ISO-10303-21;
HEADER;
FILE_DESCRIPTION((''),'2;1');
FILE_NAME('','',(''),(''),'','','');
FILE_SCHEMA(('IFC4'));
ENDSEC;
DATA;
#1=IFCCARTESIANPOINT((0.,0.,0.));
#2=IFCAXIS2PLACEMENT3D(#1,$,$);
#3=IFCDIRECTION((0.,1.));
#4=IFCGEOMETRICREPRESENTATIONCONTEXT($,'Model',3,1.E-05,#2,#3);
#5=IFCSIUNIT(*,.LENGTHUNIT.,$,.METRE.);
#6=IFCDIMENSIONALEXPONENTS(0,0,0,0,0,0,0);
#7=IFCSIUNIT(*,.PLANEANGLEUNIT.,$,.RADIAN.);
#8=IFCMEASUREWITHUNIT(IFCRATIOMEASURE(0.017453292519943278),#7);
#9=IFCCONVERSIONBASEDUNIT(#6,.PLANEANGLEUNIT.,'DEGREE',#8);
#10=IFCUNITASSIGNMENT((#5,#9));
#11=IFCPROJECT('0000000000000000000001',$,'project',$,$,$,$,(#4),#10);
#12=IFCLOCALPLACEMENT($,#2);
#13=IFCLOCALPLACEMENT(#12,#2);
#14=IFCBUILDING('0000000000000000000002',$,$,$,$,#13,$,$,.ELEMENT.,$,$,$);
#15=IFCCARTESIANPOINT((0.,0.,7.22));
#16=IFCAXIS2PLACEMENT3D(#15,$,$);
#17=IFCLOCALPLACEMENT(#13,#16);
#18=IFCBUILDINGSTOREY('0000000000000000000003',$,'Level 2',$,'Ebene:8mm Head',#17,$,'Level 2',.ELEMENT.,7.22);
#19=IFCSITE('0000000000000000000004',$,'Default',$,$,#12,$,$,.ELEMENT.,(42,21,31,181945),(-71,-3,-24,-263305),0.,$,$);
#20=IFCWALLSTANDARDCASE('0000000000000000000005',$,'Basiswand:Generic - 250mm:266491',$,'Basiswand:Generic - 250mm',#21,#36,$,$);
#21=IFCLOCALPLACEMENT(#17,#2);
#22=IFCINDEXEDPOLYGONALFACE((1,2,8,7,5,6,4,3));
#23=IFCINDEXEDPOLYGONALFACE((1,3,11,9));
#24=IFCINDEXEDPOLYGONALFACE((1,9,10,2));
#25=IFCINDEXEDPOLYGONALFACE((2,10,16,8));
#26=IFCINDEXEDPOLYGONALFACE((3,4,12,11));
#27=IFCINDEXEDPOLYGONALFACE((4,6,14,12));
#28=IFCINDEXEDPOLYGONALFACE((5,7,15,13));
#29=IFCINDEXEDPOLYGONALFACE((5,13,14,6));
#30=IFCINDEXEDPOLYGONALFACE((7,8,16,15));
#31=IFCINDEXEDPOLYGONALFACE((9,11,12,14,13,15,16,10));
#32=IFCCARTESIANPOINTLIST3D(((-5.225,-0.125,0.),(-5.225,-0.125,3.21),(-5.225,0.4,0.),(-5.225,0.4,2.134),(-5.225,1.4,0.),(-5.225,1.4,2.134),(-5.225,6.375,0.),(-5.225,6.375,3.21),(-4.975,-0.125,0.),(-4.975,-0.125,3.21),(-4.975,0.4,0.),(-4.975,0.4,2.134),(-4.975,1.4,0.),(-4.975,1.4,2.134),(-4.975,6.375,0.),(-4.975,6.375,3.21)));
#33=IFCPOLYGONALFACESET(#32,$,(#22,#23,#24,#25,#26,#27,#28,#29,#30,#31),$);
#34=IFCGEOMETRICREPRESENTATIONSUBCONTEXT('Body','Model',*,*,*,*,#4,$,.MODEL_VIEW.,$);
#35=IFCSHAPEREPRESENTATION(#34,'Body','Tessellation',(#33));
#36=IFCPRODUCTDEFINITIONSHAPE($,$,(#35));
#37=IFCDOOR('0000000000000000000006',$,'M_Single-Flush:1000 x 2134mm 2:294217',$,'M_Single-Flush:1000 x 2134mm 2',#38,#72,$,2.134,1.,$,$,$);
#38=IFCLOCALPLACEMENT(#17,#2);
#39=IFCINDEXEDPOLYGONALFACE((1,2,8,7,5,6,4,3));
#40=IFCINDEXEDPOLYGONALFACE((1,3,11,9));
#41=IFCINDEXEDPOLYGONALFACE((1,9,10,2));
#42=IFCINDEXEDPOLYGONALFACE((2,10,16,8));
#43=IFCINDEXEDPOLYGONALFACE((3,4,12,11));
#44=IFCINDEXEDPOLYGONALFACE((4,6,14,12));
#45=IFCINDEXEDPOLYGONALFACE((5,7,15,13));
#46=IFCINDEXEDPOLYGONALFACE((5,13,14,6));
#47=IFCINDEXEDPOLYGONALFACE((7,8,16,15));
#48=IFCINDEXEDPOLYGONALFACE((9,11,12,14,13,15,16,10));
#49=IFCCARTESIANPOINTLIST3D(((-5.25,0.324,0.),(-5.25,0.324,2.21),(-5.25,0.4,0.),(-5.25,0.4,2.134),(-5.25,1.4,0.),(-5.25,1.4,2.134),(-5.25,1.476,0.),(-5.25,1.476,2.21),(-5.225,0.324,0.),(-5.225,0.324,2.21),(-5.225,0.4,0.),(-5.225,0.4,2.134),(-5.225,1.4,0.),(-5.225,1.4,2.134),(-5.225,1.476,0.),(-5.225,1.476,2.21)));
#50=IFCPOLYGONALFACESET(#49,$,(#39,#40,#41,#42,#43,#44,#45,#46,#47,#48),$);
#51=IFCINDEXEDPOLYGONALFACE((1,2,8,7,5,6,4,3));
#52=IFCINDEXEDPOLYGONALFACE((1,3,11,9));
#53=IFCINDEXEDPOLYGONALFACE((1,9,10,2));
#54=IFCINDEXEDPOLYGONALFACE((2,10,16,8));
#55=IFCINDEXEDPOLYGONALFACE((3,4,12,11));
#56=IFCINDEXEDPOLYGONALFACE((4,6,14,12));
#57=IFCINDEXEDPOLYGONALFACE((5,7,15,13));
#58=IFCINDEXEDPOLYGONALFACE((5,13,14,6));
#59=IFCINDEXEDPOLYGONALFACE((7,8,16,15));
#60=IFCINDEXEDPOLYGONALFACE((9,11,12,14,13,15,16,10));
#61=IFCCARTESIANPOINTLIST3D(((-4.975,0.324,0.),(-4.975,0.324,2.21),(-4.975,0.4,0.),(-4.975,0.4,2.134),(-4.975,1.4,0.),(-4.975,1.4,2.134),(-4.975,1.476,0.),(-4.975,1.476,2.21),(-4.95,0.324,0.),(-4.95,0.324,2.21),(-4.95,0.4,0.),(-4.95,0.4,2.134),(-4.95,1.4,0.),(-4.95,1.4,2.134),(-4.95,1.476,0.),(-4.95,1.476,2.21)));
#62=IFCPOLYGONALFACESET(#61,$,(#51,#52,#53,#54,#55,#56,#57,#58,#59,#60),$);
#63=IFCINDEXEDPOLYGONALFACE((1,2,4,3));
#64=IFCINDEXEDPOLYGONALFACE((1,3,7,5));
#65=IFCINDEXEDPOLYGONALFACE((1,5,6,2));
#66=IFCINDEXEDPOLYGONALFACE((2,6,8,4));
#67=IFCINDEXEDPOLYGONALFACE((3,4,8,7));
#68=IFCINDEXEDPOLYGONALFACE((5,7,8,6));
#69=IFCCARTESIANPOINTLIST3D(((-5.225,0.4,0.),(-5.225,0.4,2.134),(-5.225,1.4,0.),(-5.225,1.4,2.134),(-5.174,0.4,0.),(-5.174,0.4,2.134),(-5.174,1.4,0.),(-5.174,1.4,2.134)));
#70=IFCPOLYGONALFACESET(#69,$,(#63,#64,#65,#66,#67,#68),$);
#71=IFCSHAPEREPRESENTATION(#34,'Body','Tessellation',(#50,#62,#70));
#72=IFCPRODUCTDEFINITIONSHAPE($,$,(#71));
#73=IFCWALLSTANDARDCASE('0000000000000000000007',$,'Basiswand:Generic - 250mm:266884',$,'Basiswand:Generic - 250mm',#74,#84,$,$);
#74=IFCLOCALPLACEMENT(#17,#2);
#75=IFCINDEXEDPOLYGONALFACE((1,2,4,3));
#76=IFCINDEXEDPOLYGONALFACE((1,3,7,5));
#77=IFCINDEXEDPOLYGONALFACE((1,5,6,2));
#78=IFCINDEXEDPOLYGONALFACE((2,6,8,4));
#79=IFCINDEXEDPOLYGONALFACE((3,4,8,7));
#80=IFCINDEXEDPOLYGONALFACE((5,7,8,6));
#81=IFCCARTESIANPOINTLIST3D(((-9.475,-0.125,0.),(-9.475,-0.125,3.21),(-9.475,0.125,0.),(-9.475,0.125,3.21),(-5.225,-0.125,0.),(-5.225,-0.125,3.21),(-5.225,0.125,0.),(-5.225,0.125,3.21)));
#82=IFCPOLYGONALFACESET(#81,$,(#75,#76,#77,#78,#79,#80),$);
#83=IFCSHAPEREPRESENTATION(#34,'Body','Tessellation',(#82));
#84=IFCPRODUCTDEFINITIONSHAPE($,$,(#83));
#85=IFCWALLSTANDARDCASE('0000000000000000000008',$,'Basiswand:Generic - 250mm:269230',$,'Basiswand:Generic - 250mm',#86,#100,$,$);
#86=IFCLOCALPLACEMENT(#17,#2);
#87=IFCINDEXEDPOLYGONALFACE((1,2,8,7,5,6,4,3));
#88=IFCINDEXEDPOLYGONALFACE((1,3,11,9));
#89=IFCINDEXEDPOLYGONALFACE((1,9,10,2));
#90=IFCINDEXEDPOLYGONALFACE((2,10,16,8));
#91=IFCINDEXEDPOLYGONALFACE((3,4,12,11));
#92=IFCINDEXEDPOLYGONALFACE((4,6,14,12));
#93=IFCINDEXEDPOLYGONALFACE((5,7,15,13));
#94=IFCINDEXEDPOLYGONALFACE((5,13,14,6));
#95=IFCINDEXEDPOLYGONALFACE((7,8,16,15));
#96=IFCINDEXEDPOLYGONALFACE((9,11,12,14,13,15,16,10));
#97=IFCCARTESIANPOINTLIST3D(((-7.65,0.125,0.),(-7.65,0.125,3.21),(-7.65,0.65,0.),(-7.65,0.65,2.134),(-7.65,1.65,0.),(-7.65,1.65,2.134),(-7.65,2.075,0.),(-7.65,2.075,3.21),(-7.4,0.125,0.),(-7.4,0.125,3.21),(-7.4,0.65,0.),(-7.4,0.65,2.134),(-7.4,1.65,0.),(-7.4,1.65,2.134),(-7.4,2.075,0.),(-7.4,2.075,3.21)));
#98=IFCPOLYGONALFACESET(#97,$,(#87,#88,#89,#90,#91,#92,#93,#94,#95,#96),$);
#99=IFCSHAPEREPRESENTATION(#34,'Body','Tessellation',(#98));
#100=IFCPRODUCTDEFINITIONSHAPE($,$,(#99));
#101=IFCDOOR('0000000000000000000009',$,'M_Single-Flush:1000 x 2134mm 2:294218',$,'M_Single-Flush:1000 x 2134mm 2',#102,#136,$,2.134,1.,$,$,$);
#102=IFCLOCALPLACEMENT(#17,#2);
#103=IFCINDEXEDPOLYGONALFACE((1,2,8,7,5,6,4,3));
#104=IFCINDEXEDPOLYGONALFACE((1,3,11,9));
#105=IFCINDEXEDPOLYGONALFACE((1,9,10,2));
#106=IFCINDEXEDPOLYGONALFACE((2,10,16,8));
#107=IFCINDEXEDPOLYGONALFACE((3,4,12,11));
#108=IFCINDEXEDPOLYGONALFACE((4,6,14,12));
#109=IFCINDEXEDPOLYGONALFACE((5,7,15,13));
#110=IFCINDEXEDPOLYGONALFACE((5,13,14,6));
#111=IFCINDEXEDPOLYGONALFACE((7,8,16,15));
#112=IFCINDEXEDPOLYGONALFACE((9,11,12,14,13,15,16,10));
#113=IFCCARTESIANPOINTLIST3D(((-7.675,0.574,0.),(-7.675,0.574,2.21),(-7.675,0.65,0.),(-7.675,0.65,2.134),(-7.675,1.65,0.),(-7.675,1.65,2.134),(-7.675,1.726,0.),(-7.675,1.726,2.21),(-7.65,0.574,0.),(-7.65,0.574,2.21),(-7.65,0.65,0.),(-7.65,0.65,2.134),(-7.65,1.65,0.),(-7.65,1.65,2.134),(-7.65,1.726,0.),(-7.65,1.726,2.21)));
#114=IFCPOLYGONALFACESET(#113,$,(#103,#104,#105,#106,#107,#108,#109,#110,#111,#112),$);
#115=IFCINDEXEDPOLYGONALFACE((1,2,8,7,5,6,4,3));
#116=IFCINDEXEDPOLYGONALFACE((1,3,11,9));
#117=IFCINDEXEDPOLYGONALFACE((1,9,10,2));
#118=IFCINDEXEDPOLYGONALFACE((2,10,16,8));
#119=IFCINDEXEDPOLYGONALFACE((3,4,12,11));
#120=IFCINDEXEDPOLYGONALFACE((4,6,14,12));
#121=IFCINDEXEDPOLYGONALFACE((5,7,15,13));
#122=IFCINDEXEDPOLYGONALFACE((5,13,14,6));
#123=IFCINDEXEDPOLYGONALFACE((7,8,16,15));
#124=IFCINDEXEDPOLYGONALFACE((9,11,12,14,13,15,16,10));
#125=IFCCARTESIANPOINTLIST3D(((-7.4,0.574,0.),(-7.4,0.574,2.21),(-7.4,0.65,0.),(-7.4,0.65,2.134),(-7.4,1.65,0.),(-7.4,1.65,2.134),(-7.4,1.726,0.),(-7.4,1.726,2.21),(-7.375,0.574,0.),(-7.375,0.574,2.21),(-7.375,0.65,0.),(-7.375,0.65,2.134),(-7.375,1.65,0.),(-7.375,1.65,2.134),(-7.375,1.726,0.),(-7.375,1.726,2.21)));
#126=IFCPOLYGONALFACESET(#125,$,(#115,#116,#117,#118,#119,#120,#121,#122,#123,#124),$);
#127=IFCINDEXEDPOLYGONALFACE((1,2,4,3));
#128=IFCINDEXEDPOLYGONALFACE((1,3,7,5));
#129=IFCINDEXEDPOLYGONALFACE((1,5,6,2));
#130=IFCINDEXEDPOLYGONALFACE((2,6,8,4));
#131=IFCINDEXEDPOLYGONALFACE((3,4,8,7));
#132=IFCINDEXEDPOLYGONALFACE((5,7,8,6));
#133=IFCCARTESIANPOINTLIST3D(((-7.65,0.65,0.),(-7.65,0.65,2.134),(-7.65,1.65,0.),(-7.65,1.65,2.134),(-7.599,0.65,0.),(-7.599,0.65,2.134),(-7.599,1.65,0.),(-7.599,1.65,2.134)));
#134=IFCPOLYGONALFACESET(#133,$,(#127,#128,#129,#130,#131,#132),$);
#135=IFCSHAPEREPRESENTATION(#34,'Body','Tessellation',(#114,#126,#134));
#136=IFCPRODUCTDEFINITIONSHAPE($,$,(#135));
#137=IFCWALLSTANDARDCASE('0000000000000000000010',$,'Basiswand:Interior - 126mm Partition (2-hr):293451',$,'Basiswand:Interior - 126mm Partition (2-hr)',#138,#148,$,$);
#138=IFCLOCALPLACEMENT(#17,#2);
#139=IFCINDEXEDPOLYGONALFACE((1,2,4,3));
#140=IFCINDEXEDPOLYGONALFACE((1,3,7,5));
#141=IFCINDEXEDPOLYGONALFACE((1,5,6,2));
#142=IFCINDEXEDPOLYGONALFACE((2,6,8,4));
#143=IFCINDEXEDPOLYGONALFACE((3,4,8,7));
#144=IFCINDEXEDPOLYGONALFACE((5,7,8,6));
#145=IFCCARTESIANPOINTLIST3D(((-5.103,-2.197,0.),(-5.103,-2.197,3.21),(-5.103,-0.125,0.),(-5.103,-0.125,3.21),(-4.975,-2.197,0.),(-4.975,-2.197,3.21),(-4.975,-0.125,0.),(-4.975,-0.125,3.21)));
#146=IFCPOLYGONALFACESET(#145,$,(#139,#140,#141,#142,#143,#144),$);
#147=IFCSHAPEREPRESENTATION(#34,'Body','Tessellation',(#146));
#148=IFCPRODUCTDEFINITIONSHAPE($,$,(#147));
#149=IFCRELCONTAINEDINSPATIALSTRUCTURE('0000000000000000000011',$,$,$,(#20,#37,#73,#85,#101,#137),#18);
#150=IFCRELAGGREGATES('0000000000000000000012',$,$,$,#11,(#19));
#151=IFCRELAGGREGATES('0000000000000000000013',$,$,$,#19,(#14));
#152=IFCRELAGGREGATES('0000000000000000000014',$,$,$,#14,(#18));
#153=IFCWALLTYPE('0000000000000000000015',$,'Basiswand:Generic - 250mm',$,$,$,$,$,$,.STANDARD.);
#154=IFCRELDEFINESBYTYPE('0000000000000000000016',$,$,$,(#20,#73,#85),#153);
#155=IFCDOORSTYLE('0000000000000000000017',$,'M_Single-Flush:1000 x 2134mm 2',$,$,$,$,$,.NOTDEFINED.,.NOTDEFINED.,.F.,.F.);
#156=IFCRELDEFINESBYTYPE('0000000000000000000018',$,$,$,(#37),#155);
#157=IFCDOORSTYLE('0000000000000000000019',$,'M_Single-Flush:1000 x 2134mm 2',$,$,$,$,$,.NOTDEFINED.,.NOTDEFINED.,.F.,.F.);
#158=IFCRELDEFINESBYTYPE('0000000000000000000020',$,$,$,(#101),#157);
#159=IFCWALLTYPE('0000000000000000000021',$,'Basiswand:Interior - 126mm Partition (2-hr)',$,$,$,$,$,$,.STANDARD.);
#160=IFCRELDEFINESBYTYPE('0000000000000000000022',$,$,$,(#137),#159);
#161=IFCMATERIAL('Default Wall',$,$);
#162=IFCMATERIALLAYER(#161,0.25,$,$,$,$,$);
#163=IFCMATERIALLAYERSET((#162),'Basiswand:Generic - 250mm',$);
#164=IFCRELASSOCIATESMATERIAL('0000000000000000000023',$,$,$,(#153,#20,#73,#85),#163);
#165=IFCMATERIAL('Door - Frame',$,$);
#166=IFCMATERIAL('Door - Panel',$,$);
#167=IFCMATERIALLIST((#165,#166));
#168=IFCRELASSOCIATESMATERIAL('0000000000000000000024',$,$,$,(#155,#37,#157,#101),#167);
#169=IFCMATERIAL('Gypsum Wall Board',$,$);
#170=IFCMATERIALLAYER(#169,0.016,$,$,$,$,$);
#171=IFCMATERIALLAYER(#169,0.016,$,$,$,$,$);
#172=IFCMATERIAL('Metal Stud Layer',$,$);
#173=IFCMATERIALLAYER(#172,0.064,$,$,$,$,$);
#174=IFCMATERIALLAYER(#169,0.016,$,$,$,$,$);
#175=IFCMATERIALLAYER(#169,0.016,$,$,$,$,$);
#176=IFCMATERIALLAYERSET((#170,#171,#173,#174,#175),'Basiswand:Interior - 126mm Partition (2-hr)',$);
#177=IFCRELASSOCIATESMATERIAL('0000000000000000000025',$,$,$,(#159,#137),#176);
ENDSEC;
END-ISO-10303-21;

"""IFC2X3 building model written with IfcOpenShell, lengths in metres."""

from ifc_helpers import new_model, entity, si_unit, converted_unit, direction, frame, frame_2d, origin, place, context, subcontext, project, spatial, polyline, rectangle, outline, extrude, clip, bounded_halfspace, source, transform, mapped, material, material_list, layer, layer_set, layer_usage, type_object, type_shapes, element, fill, save


model = new_model("IFC2X3")

# Units and contexts
model_context = context("Model", 3, precision=1e-05, world=origin(), true_north=direction((0.0, 1.0)))
body_context = subcontext(model_context, "Body", "Model", "MODEL_VIEW")
ifc_project = project(units=[si_unit("LENGTHUNIT", "METRE"), converted_unit("PLANEANGLEUNIT", "DEGREE", entity("IfcRatioMeasure", 0.017453292519943278), si_unit("PLANEANGLEUNIT", "RADIAN"), dimensions=[0, 0, 0, 0, 0, 0, 0])], contexts=[model_context])

# Site, building, storey
site_placement = place(None, origin())
site = spatial("IfcSite", under=ifc_project, at=site_placement, Name="Default", CompositionType="ELEMENT", RefLatitude=(42, 21, 31, 181945), RefLongitude=(-71, -3, -24, -263305), RefElevation=0.0)
building_placement = place(site_placement, origin())
building = spatial("IfcBuilding", under=site, at=building_placement, CompositionType="ELEMENT")
storey_placement = place(building_placement, frame((0.0, 0.0, 7.22)))
storey = spatial("IfcBuildingStorey", under=building, at=storey_placement, Name="Level 2", ObjectType="Ebene:8mm Head", LongName="Level 2", CompositionType="ELEMENT", Elevation=7.22)

# Wall, opening, door
ifc_material_1 = material(Name="Default Wall")
ifc_layer_1 = layer(ifc_material_1, 0.25)
ifc_layer_set_1 = layer_set([ifc_layer_1], Name="Basiswand:Generic - 250mm")
ifc_layer_usage_1 = layer_usage(ifc_layer_set_1, "AXIS2", "NEGATIVE", 0.125)
wall_type_1 = type_object("IfcWallType", Name="Basiswand:Generic - 250mm", PredefinedType="STANDARD", material=ifc_layer_set_1)
wall_1_placement = place(storey_placement, frame((-5.1, -0.125, 0.0), z_axis=(0.0, 0.0, 1.0), x_axis=(0.0, 1.0, 0.0)))
wall_1 = element("IfcWallStandardCase", 1, at=wall_1_placement, inside=storey, type_object=wall_type_1, material=ifc_layer_usage_1, Name="Basiswand:Generic - 250mm:266491", ObjectType="Basiswand:Generic - 250mm", context=body_context, shape_type="SweptSolid", body=[
    extrude(rectangle(XDim=6.5, YDim=0.25, at=frame_2d((3.25, 0.0), x_axis=(1.0, 0.0))), origin(), (0.0, 0.0, 1.0), 3.21),
])
opening_1_placement = place(wall_1_placement, frame((0.525, -0.125, 0.0)))
opening_1 = element("IfcOpeningElement", 2, at=opening_1_placement, cuts=wall_1, ObjectType="Opening", context=body_context, shape_type="SweptSolid", body=[
    extrude(rectangle(XDim=1.0, YDim=2.134, at=frame_2d((1.067, 0.5), x_axis=(0.0, -1.0))), frame((0.0, 0.0, 0.0), z_axis=(0.0, 1.0, 0.0), x_axis=(0.0, 0.0, 1.0)), (0.0, 0.0, 1.0), 0.25),
])
ifc_material_2 = material(Name="Door - Frame")
ifc_material_3 = material(Name="Door - Panel")
ifc_material_list_1 = material_list([ifc_material_2, ifc_material_3])
door_style_1 = type_object("IfcDoorStyle", Name="M_Single-Flush:1000 x 2134mm 2", ConstructionType="NOTDEFINED", OperationType="NOTDEFINED", ParameterTakesPrecedence=False, Sizeable=False, material=ifc_material_list_1)
shared_shape_1 = source(origin(), body_context, "Body", "SweptSolid", [
    extrude(outline(polyline([(-0.576, -1.124), (0.576, -1.124), (0.576, 1.086), (0.5, 1.086), (0.5, -1.048), (-0.5, -1.048), (-0.5, 1.086), (-0.576, 1.086), (-0.576, -1.124)])), frame((0.5, 0.275, 1.086), z_axis=(0.0, -1.0, 0.0), x_axis=(-1.0, 0.0, 0.0)), (0.0, 0.0, 1.0), 0.025),
    extrude(outline(polyline([(-1.124, -0.576), (1.086, -0.576), (1.086, -0.5), (-1.048, -0.5), (-1.048, 0.5), (1.086, 0.5), (1.086, 0.576), (-1.124, 0.576), (-1.124, -0.576)])), frame((0.5, 0.0, 1.086), z_axis=(0.0, -1.0, 0.0), x_axis=(0.0, 0.0, -1.0)), (0.0, 0.0, 1.0), 0.025),
    extrude(rectangle(XDim=1.0, YDim=0.051, at=frame_2d((0.0, 0.0), x_axis=(1.0, 0.0))), frame((0.5, 0.2245, 0.0)), (0.0, 0.0, 1.0), 2.134),
])
type_shapes(door_style_1, [shared_shape_1])
door_1_placement = place(opening_1_placement, origin())
door_1 = element("IfcDoor", 3, at=door_1_placement, inside=storey, type_object=door_style_1, material=ifc_material_list_1, Name="M_Single-Flush:1000 x 2134mm 2:294217", ObjectType="M_Single-Flush:1000 x 2134mm 2", OverallHeight=2.134, OverallWidth=1.0, context=body_context, shape_type="MappedRepresentation", body=[
    mapped(shared_shape_1, transform((0.0, 0.0, 0.0), scale=1.0)),
])
fill(opening_1, door_1)

# Wall
wall_2_placement = place(storey_placement, frame((-9.475, 0.0, 0.0)))
element("IfcWallStandardCase", 4, at=wall_2_placement, inside=storey, type_object=wall_type_1, material=ifc_layer_usage_1, Name="Basiswand:Generic - 250mm:266884", ObjectType="Basiswand:Generic - 250mm", context=body_context, shape_type="SweptSolid", body=[
    extrude(rectangle(XDim=4.25, YDim=0.25, at=frame_2d((2.125, 0.0), x_axis=(-1.0, 0.0))), origin(), (0.0, 0.0, 1.0), 3.21),
])

# Wall, opening, door
wall_3_placement = place(storey_placement, frame((-7.525, 0.125, 0.0), z_axis=(0.0, 0.0, 1.0), x_axis=(0.0, 1.0, 0.0)))
wall_3 = element("IfcWallStandardCase", 5, at=wall_3_placement, inside=storey, type_object=wall_type_1, material=ifc_layer_usage_1, Name="Basiswand:Generic - 250mm:269230", ObjectType="Basiswand:Generic - 250mm", context=body_context, shape_type="SweptSolid", body=[
    extrude(rectangle(XDim=1.95, YDim=0.25, at=frame_2d((0.975, 0.0), x_axis=(-1.0, 0.0))), origin(), (0.0, 0.0, 1.0), 3.21),
])
opening_2_placement = place(wall_3_placement, frame((0.525, -0.125, 0.0)))
opening_2 = element("IfcOpeningElement", 6, at=opening_2_placement, cuts=wall_3, ObjectType="Opening", context=body_context, shape_type="SweptSolid", body=[
    extrude(rectangle(XDim=1.0, YDim=2.134, at=frame_2d((1.067, 0.5), x_axis=(0.0, 1.0))), frame((0.0, 0.0, 0.0), z_axis=(0.0, 1.0, 0.0), x_axis=(0.0, 0.0, 1.0)), (0.0, 0.0, 1.0), 0.25),
])
door_style_2 = type_object("IfcDoorStyle", Name="M_Single-Flush:1000 x 2134mm 2", ConstructionType="NOTDEFINED", OperationType="NOTDEFINED", ParameterTakesPrecedence=False, Sizeable=False, material=ifc_material_list_1)
shared_shape_2 = source(origin(), body_context, "Body", "SweptSolid", [
    extrude(outline(polyline([(-0.576, -1.124), (0.576, -1.124), (0.576, 1.086), (0.5, 1.086), (0.5, -1.048), (-0.5, -1.048), (-0.5, 1.086), (-0.576, 1.086), (-0.576, -1.124)])), frame((0.5, 0.25, 1.086), z_axis=(0.0, 1.0, 0.0), x_axis=(1.0, 0.0, 0.0)), (0.0, 0.0, 1.0), 0.025),
    extrude(outline(polyline([(-1.124, -0.576), (1.086, -0.576), (1.086, -0.5), (-1.048, -0.5), (-1.048, 0.5), (1.086, 0.5), (1.086, 0.576), (-1.124, 0.576), (-1.124, -0.576)])), frame((0.5, -0.025, 1.086), z_axis=(0.0, 1.0, 0.0), x_axis=(0.0, 0.0, -1.0)), (0.0, 0.0, 1.0), 0.025),
    extrude(rectangle(XDim=0.051, YDim=1.0, at=frame_2d((0.0, 0.0), x_axis=(1.0, 0.0))), frame((0.5, 0.2245, 0.0), z_axis=(0.0, 0.0, 1.0), x_axis=(0.0, 1.0, 0.0)), (0.0, 0.0, 1.0), 2.134),
])
type_shapes(door_style_2, [shared_shape_2])
door_2_placement = place(opening_2_placement, origin())
door_2 = element("IfcDoor", 7, at=door_2_placement, inside=storey, type_object=door_style_2, material=ifc_material_list_1, Name="M_Single-Flush:1000 x 2134mm 2:294218", ObjectType="M_Single-Flush:1000 x 2134mm 2", OverallHeight=2.134, OverallWidth=1.0, context=body_context, shape_type="MappedRepresentation", body=[
    mapped(shared_shape_2, transform((0.0, 0.0, 0.0), scale=1.0)),
])
fill(opening_2, door_2)

# Wall
ifc_material_4 = material(Name="Gypsum Wall Board")
ifc_layer_2 = layer(ifc_material_4, 0.016)
ifc_layer_3 = layer(ifc_material_4, 0.016)
ifc_material_5 = material(Name="Metal Stud Layer")
ifc_layer_4 = layer(ifc_material_5, 0.064)
ifc_layer_5 = layer(ifc_material_4, 0.016)
ifc_layer_6 = layer(ifc_material_4, 0.016)
ifc_layer_set_2 = layer_set([ifc_layer_2, ifc_layer_3, ifc_layer_4, ifc_layer_5, ifc_layer_6], Name="Basiswand:Interior - 126mm Partition (2-hr)")
ifc_layer_usage_2 = layer_usage(ifc_layer_set_2, "AXIS2", "NEGATIVE", 0.064)
wall_type_2 = type_object("IfcWallType", Name="Basiswand:Interior - 126mm Partition (2-hr)", PredefinedType="STANDARD", material=ifc_layer_set_2)
wall_4_placement = place(storey_placement, frame((-5.039, -0.125, 0.0), z_axis=(0.0, 0.0, 1.0), x_axis=(0.0, -1.0, 0.0)))
element("IfcWallStandardCase", 8, at=wall_4_placement, inside=storey, type_object=wall_type_2, material=ifc_layer_usage_2, Name="Basiswand:Interior - 126mm Partition (2-hr):293451", ObjectType="Basiswand:Interior - 126mm Partition (2-hr)", context=body_context, shape_type="Clipping", body=[
    clip(extrude(rectangle(XDim=2.072, YDim=0.128, at=frame_2d((1.036, 0.0), x_axis=(-1.0, 0.0))), origin(), (0.0, 0.0, 1.0), 3.21), bounded_halfspace(frame((0.0, -0.064, 3.21), z_axis=(0.0, 0.0, -1.0), x_axis=(-1.0, 0.0, 0.0)), True, frame((0.0, -0.064, 3.21)), polyline([(0.0, 0.0), (2.072, 0.0), (2.072, 0.128), (1.353, 0.128), (1.225, 0.128), (0.0, 0.128), (0.0, 0.0)]))),
])

save(model, "model.ifc")
